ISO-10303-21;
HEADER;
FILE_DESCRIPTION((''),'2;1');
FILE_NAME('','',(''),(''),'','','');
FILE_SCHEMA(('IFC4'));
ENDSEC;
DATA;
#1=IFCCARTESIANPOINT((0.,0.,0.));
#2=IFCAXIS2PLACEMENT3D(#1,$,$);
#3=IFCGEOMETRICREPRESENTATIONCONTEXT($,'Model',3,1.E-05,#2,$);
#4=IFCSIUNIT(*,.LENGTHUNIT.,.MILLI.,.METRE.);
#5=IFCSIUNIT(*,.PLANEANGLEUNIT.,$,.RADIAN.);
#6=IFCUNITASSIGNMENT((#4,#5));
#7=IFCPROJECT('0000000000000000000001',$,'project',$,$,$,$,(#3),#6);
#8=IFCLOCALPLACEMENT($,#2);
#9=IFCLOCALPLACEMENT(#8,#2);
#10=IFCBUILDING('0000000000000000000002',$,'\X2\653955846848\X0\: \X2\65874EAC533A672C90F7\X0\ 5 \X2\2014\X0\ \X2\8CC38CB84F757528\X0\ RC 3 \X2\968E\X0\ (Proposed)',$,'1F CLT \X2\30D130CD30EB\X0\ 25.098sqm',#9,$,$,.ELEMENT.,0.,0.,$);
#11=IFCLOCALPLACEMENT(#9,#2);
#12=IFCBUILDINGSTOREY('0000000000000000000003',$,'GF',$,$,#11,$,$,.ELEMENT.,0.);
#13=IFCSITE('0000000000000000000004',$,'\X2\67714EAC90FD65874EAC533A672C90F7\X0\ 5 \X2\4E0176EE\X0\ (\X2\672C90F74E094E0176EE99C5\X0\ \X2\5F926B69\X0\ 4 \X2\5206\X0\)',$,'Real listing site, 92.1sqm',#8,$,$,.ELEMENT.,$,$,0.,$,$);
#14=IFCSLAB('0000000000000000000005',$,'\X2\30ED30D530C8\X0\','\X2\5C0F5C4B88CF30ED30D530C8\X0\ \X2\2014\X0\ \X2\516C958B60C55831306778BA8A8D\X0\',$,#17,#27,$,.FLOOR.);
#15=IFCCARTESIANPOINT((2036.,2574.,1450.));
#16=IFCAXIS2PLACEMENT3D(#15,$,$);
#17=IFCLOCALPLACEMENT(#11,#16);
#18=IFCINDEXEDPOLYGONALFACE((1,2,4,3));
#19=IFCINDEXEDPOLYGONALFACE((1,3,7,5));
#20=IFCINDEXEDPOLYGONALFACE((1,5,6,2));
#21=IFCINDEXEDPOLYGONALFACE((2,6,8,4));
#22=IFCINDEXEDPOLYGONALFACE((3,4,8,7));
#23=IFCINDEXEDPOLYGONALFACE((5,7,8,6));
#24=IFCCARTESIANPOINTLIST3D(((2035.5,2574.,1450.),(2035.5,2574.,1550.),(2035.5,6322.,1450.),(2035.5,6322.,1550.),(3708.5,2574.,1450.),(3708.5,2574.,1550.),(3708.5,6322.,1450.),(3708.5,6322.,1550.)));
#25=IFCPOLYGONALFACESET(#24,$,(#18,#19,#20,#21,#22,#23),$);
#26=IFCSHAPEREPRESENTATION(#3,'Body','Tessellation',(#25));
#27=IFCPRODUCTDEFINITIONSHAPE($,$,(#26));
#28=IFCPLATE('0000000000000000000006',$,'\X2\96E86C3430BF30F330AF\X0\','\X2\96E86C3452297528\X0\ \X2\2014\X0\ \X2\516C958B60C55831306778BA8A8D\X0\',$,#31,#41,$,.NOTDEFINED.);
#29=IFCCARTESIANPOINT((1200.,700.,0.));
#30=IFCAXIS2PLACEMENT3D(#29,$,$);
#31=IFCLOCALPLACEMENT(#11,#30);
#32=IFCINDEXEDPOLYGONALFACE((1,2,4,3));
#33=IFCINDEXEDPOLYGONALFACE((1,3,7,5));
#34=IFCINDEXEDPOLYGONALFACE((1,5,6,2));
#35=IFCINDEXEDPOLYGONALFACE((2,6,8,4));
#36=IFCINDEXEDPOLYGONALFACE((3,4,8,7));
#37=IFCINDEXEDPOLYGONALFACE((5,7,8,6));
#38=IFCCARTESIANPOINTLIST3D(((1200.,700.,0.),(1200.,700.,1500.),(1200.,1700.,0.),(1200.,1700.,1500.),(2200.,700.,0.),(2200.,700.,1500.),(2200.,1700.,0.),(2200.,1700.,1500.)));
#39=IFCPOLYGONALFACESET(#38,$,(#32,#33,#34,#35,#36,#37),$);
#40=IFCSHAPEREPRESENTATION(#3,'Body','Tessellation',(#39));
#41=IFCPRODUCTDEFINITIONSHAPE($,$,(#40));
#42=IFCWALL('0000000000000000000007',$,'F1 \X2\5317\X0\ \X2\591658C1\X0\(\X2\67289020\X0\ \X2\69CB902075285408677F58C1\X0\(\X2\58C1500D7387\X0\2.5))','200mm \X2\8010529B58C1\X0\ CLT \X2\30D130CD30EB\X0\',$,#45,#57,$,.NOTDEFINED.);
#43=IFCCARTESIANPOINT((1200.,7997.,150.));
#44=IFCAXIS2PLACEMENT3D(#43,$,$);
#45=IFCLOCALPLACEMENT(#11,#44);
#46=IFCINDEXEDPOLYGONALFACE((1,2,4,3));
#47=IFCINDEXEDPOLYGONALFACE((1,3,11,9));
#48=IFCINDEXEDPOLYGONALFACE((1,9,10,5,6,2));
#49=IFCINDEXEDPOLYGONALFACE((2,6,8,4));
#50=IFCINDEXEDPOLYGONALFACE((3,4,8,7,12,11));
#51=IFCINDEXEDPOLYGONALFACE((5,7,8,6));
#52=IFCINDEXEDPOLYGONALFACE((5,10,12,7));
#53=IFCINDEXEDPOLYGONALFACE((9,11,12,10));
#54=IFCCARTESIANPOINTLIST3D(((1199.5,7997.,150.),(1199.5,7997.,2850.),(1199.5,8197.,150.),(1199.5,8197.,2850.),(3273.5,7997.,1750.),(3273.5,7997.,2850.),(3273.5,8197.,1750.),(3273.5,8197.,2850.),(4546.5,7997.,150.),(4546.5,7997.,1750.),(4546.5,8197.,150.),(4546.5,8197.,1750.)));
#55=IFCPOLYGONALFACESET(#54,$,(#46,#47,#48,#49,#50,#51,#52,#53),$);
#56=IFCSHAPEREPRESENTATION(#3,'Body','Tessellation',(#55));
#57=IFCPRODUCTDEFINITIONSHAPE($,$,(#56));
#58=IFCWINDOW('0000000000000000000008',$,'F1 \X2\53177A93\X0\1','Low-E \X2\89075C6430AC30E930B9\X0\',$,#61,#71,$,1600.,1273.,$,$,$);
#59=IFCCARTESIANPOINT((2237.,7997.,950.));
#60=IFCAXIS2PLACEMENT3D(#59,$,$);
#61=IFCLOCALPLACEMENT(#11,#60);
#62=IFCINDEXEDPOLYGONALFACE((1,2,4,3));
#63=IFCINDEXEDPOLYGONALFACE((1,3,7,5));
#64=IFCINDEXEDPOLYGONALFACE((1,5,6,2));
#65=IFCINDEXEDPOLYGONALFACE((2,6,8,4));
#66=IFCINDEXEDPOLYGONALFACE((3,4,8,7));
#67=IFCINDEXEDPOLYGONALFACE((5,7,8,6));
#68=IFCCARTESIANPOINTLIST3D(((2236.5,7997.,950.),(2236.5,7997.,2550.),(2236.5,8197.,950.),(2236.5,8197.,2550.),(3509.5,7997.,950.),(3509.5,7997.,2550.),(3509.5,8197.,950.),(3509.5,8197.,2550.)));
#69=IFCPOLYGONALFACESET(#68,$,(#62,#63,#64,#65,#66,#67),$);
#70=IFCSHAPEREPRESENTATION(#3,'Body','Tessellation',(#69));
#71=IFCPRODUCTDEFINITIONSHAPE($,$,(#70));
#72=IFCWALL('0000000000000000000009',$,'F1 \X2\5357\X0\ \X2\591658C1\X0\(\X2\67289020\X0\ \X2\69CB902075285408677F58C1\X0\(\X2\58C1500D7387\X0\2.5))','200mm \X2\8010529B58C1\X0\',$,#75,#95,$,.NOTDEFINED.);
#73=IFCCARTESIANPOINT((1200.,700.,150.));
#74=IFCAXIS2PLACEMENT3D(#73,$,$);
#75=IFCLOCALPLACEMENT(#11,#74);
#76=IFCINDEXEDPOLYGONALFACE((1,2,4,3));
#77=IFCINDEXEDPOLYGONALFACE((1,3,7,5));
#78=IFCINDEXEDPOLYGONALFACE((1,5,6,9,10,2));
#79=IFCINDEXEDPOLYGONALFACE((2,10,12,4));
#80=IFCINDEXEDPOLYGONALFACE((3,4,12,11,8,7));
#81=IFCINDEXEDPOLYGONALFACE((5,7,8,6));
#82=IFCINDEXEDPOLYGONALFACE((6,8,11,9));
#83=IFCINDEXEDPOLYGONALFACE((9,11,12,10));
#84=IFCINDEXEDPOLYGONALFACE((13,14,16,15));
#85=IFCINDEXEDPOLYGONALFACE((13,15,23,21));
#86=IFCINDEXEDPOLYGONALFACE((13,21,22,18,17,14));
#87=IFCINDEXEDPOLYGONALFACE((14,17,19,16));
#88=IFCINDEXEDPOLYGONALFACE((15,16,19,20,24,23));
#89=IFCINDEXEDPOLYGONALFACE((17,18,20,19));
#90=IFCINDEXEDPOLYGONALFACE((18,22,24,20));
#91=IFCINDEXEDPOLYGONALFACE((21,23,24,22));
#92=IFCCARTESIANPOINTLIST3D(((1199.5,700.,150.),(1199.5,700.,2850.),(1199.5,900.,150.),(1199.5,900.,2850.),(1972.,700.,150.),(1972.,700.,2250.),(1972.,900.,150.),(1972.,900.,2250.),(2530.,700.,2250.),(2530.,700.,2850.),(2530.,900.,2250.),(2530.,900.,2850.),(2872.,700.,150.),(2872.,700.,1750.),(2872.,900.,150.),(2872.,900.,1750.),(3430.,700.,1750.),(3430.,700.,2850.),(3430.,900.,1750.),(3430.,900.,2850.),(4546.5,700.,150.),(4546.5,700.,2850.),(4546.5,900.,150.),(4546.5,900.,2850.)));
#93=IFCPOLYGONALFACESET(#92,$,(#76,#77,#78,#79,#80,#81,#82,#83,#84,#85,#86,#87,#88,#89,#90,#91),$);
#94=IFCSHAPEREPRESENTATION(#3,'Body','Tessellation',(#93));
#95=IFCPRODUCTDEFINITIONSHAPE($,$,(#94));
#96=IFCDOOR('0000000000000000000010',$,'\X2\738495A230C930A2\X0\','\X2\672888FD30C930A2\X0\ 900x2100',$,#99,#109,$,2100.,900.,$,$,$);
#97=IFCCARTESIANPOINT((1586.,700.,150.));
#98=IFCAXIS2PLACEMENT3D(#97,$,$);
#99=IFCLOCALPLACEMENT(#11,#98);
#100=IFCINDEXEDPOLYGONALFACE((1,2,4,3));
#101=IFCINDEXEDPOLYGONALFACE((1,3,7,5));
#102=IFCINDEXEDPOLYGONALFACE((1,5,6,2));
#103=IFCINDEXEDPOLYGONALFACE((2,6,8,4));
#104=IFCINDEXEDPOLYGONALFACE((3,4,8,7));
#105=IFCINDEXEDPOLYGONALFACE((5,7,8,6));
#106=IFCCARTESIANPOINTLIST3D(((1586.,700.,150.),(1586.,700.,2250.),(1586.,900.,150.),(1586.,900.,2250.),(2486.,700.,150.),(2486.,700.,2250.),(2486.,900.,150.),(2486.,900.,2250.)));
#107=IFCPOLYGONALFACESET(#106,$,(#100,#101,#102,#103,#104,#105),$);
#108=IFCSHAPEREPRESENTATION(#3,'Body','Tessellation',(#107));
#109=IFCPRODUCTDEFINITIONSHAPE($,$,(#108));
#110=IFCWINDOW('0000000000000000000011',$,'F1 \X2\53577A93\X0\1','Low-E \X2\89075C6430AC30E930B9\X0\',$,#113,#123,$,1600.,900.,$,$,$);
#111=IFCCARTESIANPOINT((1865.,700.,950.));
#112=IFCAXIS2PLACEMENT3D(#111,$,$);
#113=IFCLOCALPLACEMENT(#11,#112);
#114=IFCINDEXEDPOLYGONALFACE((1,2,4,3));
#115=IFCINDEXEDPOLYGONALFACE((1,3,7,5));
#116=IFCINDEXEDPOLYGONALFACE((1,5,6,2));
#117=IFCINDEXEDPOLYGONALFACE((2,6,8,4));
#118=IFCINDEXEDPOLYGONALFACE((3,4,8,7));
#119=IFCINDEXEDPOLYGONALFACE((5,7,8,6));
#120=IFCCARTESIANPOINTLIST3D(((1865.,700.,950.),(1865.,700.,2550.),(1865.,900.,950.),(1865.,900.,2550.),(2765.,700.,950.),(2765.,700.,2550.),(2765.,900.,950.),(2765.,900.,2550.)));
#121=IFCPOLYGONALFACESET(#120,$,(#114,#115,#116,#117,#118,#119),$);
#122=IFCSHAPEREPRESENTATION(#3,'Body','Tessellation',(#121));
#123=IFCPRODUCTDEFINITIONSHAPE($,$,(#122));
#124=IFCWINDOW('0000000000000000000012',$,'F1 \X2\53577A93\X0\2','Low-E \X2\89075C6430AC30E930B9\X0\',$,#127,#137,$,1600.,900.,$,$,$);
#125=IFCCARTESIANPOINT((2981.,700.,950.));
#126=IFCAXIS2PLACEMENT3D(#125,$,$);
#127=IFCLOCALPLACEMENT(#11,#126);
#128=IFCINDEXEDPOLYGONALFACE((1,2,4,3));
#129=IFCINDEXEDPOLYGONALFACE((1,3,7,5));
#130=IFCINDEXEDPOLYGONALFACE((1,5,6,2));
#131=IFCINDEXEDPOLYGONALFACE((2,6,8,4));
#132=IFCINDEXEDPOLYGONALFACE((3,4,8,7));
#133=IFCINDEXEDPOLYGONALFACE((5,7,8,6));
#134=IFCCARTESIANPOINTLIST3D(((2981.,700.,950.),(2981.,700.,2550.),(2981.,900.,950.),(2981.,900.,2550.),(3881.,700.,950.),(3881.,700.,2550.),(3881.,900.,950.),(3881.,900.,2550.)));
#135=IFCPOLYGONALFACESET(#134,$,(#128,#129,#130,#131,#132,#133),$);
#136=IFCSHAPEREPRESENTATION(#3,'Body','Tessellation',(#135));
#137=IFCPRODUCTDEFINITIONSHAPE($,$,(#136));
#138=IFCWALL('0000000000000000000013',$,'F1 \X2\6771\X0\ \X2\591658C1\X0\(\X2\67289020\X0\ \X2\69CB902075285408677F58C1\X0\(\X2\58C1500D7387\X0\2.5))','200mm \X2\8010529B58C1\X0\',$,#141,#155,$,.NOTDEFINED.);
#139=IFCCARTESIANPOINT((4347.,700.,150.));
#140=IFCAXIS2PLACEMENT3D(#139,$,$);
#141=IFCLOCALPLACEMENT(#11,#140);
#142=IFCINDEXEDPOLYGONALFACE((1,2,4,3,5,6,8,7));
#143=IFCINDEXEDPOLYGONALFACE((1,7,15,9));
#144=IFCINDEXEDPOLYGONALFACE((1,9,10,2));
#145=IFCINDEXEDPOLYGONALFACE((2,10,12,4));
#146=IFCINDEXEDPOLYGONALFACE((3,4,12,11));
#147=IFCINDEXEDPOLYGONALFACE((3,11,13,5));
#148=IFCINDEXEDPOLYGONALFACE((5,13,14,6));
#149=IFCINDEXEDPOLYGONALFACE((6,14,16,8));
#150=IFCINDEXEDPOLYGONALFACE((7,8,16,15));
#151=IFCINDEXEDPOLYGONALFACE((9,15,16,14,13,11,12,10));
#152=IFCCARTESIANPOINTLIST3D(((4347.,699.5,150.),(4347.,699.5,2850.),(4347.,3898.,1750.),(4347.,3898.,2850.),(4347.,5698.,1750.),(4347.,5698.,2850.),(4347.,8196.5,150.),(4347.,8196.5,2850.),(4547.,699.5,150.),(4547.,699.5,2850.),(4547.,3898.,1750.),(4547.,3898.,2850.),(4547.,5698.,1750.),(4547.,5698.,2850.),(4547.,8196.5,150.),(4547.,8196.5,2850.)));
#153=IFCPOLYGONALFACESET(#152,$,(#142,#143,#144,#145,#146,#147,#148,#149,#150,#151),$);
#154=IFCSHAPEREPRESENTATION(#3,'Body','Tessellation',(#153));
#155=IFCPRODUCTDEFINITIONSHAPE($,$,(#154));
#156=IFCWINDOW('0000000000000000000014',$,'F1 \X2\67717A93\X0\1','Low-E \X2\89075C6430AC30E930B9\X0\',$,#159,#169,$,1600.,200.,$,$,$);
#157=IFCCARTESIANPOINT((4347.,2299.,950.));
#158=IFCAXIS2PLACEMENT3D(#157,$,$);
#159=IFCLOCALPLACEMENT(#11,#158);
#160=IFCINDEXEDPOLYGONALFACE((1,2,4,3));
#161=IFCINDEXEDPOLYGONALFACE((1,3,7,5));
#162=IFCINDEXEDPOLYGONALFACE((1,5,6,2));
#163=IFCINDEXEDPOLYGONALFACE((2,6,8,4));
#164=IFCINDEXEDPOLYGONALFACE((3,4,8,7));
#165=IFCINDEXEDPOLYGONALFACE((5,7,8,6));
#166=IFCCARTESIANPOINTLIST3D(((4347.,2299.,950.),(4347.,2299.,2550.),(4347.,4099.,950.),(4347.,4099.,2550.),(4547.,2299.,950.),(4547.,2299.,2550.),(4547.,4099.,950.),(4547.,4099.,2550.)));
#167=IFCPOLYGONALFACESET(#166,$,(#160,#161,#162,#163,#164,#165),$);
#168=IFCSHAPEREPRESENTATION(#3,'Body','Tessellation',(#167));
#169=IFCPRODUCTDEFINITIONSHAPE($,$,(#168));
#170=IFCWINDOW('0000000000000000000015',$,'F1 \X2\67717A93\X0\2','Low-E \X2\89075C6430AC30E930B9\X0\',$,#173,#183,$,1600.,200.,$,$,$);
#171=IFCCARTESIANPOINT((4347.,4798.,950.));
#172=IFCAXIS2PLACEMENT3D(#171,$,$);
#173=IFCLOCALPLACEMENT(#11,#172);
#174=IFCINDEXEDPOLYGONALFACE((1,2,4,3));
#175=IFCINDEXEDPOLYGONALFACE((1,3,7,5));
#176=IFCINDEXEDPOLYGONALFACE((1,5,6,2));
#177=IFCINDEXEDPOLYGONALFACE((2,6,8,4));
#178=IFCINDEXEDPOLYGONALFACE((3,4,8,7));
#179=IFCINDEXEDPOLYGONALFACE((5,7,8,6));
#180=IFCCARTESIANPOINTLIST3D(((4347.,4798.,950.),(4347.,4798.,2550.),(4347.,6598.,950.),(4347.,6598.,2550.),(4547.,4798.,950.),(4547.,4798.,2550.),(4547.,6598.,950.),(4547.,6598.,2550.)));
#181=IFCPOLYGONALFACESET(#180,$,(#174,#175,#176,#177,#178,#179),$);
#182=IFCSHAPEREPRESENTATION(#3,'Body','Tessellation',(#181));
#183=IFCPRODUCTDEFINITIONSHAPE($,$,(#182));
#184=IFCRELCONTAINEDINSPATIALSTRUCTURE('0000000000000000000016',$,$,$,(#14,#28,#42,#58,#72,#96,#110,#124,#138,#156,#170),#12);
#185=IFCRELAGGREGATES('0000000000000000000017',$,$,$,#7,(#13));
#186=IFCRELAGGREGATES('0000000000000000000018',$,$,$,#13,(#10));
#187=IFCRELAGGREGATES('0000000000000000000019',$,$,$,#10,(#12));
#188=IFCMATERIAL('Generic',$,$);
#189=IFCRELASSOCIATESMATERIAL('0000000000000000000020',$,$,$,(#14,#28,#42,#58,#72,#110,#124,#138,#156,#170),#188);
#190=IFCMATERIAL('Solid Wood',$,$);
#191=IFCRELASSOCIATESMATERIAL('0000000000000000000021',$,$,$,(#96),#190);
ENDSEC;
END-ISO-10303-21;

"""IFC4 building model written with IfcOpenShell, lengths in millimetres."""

from ifc_helpers import new_model, si_unit, frame, frame_2d, origin, place, context, project, spatial, rectangle, extrude, material, element, fill, save


model = new_model("IFC4")

# Units and contexts
model_context = context("Model", 3, precision=1e-05, world=origin())
ifc_project = project(units=[si_unit("LENGTHUNIT", "METRE", prefix="MILLI"), si_unit("PLANEANGLEUNIT", "RADIAN")], contexts=[model_context])

# Site, building, storey
site_placement = place(None, origin())
site = spatial("IfcSite", under=ifc_project, at=site_placement, Name="東京都文京区本郷 5 丁目 (本郷三丁目駅 徒歩 4 分)", ObjectType="Real listing site, 92.1sqm", CompositionType="ELEMENT", RefElevation=0.0)
building_placement = place(site_placement, origin())
building = spatial("IfcBuilding", under=site, at=building_placement, Name="改善案: 文京区本郷 5 — 賃貸併用 RC 3 階 (Proposed)", ObjectType="1F CLT パネル 25.098sqm", CompositionType="ELEMENT", ElevationOfRefHeight=0.0, ElevationOfTerrain=0.0)
storey_placement = place(building_placement, origin())
storey = spatial("IfcBuildingStorey", under=building, at=storey_placement, Name="GF", CompositionType="ELEMENT", Elevation=0.0)

# Slab
ifc_material_1 = material(Name="Generic")
slab_1_placement = place(storey_placement, frame((2036.0, 2574.0, 1450.0)))
element("IfcSlab", 1, at=slab_1_placement, inside=storey, material=ifc_material_1, Name="ロフト", Description="小屋裏ロフト — 公開情報で確認", PredefinedType="FLOOR", context=model_context, shape_type="SweptSolid", body=[
    extrude(rectangle(XDim=1673.0, YDim=3748.0, at=frame_2d((836.0, 1874.0))), frame((2036.0, 2574.0, 1450.0)), (0.0, 0.0, 1.0), 100.0),
])

# Plate
plate_placement = place(storey_placement, frame((1200.0, 700.0, 0.0)))
element("IfcPlate", 2, at=plate_placement, inside=storey, material=ifc_material_1, Name="雨水タンク", Description="雨水利用 — 公開情報で確認", PredefinedType="NOTDEFINED", context=model_context, shape_type="SweptSolid", body=[
    extrude(rectangle(XDim=1000.0, YDim=1000.0, at=frame_2d((500.0, 500.0))), frame((1200.0, 700.0, 0.0)), (0.0, 0.0, 1.0), 1500.0),
])

# Wall, opening, window
wall_1_placement = place(storey_placement, frame((1200.0, 7997.0, 150.0)))
wall_1 = element("IfcWall", 3, at=wall_1_placement, inside=storey, material=ifc_material_1, Name="F1 北 外壁(木造 構造用合板壁(壁倍率2.5))", Description="200mm 耐力壁 CLT パネル", PredefinedType="NOTDEFINED", context=model_context, shape_type="SweptSolid", body=[
    extrude(rectangle(XDim=3347.0, YDim=200.0, at=frame_2d((1673.0, 100.0))), frame((1200.0, 7997.0, 150.0)), (0.0, 0.0, 1.0), 2700.0),
])
opening_1_placement = place(storey_placement, frame((2237.0, 7997.0, 950.0)))
opening_1 = element("IfcOpeningElement", 4, at=opening_1_placement, cuts=wall_1, PredefinedType="NOTDEFINED", context=model_context, shape_type="SweptSolid", body=[
    extrude(rectangle(XDim=1273.0, YDim=200.0, at=frame_2d((636.0, 100.0))), frame((2237.0, 7997.0, 950.0)), (0.0, 0.0, 1.0), 1600.0),
])
window_1_placement = place(storey_placement, frame((2237.0, 7997.0, 950.0)))
window_1 = element("IfcWindow", 5, at=window_1_placement, inside=storey, material=ifc_material_1, Name="F1 北窓1", Description="Low-E 複層ガラス", OverallHeight=1600.0, OverallWidth=1273.0, context=model_context, shape_type="SweptSolid", body=[
    extrude(rectangle(XDim=1273.0, YDim=200.0, at=frame_2d((636.0, 100.0))), frame((2237.0, 7997.0, 950.0)), (0.0, 0.0, 1.0), 1600.0),
])
fill(opening_1, window_1)

# Wall, openings, door, windows
wall_2_placement = place(storey_placement, frame((1200.0, 700.0, 150.0)))
wall_2 = element("IfcWall", 6, at=wall_2_placement, inside=storey, material=ifc_material_1, Name="F1 南 外壁(木造 構造用合板壁(壁倍率2.5))", Description="200mm 耐力壁", PredefinedType="NOTDEFINED", context=model_context, shape_type="SweptSolid", body=[
    extrude(rectangle(XDim=3347.0, YDim=200.0, at=frame_2d((1673.0, 100.0))), frame((1200.0, 700.0, 150.0)), (0.0, 0.0, 1.0), 2700.0),
])
opening_2_placement = place(storey_placement, frame((1586.0, 700.0, 150.0)))
opening_2 = element("IfcOpeningElement", 7, at=opening_2_placement, cuts=wall_2, PredefinedType="NOTDEFINED", context=model_context, shape_type="SweptSolid", body=[
    extrude(rectangle(XDim=900.0, YDim=200.0, at=frame_2d((450.0, 100.0))), frame((1586.0, 700.0, 150.0)), (0.0, 0.0, 1.0), 2100.0),
])
opening_3_placement = place(storey_placement, frame((1865.0, 700.0, 950.0)))
opening_3 = element("IfcOpeningElement", 8, at=opening_3_placement, cuts=wall_2, PredefinedType="NOTDEFINED", context=model_context, shape_type="SweptSolid", body=[
    extrude(rectangle(XDim=900.0, YDim=200.0, at=frame_2d((450.0, 100.0))), frame((1865.0, 700.0, 950.0)), (0.0, 0.0, 1.0), 1600.0),
])
opening_4_placement = place(storey_placement, frame((2981.0, 700.0, 950.0)))
opening_4 = element("IfcOpeningElement", 9, at=opening_4_placement, cuts=wall_2, PredefinedType="NOTDEFINED", context=model_context, shape_type="SweptSolid", body=[
    extrude(rectangle(XDim=900.0, YDim=200.0, at=frame_2d((450.0, 100.0))), frame((2981.0, 700.0, 950.0)), (0.0, 0.0, 1.0), 1600.0),
])
ifc_material_2 = material(Name="Solid Wood")
door_placement = place(storey_placement, frame((1586.0, 700.0, 150.0)))
door = element("IfcDoor", 10, at=door_placement, inside=storey, material=ifc_material_2, Name="玄関ドア", Description="木製ドア 900x2100", OverallHeight=2100.0, OverallWidth=900.0, context=model_context, shape_type="SweptSolid", body=[
    extrude(rectangle(XDim=900.0, YDim=200.0, at=frame_2d((450.0, 100.0))), frame((1586.0, 700.0, 150.0)), (0.0, 0.0, 1.0), 2100.0),
])
fill(opening_2, door)
window_2_placement = place(storey_placement, frame((1865.0, 700.0, 950.0)))
window_2 = element("IfcWindow", 11, at=window_2_placement, inside=storey, material=ifc_material_1, Name="F1 南窓1", Description="Low-E 複層ガラス", OverallHeight=1600.0, OverallWidth=900.0, context=model_context, shape_type="SweptSolid", body=[
    extrude(rectangle(XDim=900.0, YDim=200.0, at=frame_2d((450.0, 100.0))), frame((1865.0, 700.0, 950.0)), (0.0, 0.0, 1.0), 1600.0),
])
fill(opening_3, window_2)
window_3_placement = place(storey_placement, frame((2981.0, 700.0, 950.0)))
window_3 = element("IfcWindow", 12, at=window_3_placement, inside=storey, material=ifc_material_1, Name="F1 南窓2", Description="Low-E 複層ガラス", OverallHeight=1600.0, OverallWidth=900.0, context=model_context, shape_type="SweptSolid", body=[
    extrude(rectangle(XDim=900.0, YDim=200.0, at=frame_2d((450.0, 100.0))), frame((2981.0, 700.0, 950.0)), (0.0, 0.0, 1.0), 1600.0),
])
fill(opening_4, window_3)

# Wall, openings, windows
wall_3_placement = place(storey_placement, frame((4347.0, 700.0, 150.0)))
wall_3 = element("IfcWall", 13, at=wall_3_placement, inside=storey, material=ifc_material_1, Name="F1 東 外壁(木造 構造用合板壁(壁倍率2.5))", Description="200mm 耐力壁", PredefinedType="NOTDEFINED", context=model_context, shape_type="SweptSolid", body=[
    extrude(rectangle(XDim=200.0, YDim=7497.0, at=frame_2d((100.0, 3748.0))), frame((4347.0, 700.0, 150.0)), (0.0, 0.0, 1.0), 2700.0),
])
opening_5_placement = place(storey_placement, frame((4347.0, 2299.0, 950.0)))
opening_5 = element("IfcOpeningElement", 14, at=opening_5_placement, cuts=wall_3, PredefinedType="NOTDEFINED", context=model_context, shape_type="SweptSolid", body=[
    extrude(rectangle(XDim=200.0, YDim=1800.0, at=frame_2d((100.0, 900.0))), frame((4347.0, 2299.0, 950.0)), (0.0, 0.0, 1.0), 1600.0),
])
opening_6_placement = place(storey_placement, frame((4347.0, 4798.0, 950.0)))
opening_6 = element("IfcOpeningElement", 15, at=opening_6_placement, cuts=wall_3, PredefinedType="NOTDEFINED", context=model_context, shape_type="SweptSolid", body=[
    extrude(rectangle(XDim=200.0, YDim=1800.0, at=frame_2d((100.0, 900.0))), frame((4347.0, 4798.0, 950.0)), (0.0, 0.0, 1.0), 1600.0),
])
window_4_placement = place(storey_placement, frame((4347.0, 2299.0, 950.0)))
window_4 = element("IfcWindow", 16, at=window_4_placement, inside=storey, material=ifc_material_1, Name="F1 東窓1", Description="Low-E 複層ガラス", OverallHeight=1600.0, OverallWidth=200.0, context=model_context, shape_type="SweptSolid", body=[
    extrude(rectangle(XDim=200.0, YDim=1800.0, at=frame_2d((100.0, 900.0))), frame((4347.0, 2299.0, 950.0)), (0.0, 0.0, 1.0), 1600.0),
])
fill(opening_5, window_4)
window_5_placement = place(storey_placement, frame((4347.0, 4798.0, 950.0)))
window_5 = element("IfcWindow", 17, at=window_5_placement, inside=storey, material=ifc_material_1, Name="F1 東窓2", Description="Low-E 複層ガラス", OverallHeight=1600.0, OverallWidth=200.0, context=model_context, shape_type="SweptSolid", body=[
    extrude(rectangle(XDim=200.0, YDim=1800.0, at=frame_2d((100.0, 900.0))), frame((4347.0, 4798.0, 950.0)), (0.0, 0.0, 1.0), 1600.0),
])
fill(opening_6, window_5)

save(model, "model.ifc")
